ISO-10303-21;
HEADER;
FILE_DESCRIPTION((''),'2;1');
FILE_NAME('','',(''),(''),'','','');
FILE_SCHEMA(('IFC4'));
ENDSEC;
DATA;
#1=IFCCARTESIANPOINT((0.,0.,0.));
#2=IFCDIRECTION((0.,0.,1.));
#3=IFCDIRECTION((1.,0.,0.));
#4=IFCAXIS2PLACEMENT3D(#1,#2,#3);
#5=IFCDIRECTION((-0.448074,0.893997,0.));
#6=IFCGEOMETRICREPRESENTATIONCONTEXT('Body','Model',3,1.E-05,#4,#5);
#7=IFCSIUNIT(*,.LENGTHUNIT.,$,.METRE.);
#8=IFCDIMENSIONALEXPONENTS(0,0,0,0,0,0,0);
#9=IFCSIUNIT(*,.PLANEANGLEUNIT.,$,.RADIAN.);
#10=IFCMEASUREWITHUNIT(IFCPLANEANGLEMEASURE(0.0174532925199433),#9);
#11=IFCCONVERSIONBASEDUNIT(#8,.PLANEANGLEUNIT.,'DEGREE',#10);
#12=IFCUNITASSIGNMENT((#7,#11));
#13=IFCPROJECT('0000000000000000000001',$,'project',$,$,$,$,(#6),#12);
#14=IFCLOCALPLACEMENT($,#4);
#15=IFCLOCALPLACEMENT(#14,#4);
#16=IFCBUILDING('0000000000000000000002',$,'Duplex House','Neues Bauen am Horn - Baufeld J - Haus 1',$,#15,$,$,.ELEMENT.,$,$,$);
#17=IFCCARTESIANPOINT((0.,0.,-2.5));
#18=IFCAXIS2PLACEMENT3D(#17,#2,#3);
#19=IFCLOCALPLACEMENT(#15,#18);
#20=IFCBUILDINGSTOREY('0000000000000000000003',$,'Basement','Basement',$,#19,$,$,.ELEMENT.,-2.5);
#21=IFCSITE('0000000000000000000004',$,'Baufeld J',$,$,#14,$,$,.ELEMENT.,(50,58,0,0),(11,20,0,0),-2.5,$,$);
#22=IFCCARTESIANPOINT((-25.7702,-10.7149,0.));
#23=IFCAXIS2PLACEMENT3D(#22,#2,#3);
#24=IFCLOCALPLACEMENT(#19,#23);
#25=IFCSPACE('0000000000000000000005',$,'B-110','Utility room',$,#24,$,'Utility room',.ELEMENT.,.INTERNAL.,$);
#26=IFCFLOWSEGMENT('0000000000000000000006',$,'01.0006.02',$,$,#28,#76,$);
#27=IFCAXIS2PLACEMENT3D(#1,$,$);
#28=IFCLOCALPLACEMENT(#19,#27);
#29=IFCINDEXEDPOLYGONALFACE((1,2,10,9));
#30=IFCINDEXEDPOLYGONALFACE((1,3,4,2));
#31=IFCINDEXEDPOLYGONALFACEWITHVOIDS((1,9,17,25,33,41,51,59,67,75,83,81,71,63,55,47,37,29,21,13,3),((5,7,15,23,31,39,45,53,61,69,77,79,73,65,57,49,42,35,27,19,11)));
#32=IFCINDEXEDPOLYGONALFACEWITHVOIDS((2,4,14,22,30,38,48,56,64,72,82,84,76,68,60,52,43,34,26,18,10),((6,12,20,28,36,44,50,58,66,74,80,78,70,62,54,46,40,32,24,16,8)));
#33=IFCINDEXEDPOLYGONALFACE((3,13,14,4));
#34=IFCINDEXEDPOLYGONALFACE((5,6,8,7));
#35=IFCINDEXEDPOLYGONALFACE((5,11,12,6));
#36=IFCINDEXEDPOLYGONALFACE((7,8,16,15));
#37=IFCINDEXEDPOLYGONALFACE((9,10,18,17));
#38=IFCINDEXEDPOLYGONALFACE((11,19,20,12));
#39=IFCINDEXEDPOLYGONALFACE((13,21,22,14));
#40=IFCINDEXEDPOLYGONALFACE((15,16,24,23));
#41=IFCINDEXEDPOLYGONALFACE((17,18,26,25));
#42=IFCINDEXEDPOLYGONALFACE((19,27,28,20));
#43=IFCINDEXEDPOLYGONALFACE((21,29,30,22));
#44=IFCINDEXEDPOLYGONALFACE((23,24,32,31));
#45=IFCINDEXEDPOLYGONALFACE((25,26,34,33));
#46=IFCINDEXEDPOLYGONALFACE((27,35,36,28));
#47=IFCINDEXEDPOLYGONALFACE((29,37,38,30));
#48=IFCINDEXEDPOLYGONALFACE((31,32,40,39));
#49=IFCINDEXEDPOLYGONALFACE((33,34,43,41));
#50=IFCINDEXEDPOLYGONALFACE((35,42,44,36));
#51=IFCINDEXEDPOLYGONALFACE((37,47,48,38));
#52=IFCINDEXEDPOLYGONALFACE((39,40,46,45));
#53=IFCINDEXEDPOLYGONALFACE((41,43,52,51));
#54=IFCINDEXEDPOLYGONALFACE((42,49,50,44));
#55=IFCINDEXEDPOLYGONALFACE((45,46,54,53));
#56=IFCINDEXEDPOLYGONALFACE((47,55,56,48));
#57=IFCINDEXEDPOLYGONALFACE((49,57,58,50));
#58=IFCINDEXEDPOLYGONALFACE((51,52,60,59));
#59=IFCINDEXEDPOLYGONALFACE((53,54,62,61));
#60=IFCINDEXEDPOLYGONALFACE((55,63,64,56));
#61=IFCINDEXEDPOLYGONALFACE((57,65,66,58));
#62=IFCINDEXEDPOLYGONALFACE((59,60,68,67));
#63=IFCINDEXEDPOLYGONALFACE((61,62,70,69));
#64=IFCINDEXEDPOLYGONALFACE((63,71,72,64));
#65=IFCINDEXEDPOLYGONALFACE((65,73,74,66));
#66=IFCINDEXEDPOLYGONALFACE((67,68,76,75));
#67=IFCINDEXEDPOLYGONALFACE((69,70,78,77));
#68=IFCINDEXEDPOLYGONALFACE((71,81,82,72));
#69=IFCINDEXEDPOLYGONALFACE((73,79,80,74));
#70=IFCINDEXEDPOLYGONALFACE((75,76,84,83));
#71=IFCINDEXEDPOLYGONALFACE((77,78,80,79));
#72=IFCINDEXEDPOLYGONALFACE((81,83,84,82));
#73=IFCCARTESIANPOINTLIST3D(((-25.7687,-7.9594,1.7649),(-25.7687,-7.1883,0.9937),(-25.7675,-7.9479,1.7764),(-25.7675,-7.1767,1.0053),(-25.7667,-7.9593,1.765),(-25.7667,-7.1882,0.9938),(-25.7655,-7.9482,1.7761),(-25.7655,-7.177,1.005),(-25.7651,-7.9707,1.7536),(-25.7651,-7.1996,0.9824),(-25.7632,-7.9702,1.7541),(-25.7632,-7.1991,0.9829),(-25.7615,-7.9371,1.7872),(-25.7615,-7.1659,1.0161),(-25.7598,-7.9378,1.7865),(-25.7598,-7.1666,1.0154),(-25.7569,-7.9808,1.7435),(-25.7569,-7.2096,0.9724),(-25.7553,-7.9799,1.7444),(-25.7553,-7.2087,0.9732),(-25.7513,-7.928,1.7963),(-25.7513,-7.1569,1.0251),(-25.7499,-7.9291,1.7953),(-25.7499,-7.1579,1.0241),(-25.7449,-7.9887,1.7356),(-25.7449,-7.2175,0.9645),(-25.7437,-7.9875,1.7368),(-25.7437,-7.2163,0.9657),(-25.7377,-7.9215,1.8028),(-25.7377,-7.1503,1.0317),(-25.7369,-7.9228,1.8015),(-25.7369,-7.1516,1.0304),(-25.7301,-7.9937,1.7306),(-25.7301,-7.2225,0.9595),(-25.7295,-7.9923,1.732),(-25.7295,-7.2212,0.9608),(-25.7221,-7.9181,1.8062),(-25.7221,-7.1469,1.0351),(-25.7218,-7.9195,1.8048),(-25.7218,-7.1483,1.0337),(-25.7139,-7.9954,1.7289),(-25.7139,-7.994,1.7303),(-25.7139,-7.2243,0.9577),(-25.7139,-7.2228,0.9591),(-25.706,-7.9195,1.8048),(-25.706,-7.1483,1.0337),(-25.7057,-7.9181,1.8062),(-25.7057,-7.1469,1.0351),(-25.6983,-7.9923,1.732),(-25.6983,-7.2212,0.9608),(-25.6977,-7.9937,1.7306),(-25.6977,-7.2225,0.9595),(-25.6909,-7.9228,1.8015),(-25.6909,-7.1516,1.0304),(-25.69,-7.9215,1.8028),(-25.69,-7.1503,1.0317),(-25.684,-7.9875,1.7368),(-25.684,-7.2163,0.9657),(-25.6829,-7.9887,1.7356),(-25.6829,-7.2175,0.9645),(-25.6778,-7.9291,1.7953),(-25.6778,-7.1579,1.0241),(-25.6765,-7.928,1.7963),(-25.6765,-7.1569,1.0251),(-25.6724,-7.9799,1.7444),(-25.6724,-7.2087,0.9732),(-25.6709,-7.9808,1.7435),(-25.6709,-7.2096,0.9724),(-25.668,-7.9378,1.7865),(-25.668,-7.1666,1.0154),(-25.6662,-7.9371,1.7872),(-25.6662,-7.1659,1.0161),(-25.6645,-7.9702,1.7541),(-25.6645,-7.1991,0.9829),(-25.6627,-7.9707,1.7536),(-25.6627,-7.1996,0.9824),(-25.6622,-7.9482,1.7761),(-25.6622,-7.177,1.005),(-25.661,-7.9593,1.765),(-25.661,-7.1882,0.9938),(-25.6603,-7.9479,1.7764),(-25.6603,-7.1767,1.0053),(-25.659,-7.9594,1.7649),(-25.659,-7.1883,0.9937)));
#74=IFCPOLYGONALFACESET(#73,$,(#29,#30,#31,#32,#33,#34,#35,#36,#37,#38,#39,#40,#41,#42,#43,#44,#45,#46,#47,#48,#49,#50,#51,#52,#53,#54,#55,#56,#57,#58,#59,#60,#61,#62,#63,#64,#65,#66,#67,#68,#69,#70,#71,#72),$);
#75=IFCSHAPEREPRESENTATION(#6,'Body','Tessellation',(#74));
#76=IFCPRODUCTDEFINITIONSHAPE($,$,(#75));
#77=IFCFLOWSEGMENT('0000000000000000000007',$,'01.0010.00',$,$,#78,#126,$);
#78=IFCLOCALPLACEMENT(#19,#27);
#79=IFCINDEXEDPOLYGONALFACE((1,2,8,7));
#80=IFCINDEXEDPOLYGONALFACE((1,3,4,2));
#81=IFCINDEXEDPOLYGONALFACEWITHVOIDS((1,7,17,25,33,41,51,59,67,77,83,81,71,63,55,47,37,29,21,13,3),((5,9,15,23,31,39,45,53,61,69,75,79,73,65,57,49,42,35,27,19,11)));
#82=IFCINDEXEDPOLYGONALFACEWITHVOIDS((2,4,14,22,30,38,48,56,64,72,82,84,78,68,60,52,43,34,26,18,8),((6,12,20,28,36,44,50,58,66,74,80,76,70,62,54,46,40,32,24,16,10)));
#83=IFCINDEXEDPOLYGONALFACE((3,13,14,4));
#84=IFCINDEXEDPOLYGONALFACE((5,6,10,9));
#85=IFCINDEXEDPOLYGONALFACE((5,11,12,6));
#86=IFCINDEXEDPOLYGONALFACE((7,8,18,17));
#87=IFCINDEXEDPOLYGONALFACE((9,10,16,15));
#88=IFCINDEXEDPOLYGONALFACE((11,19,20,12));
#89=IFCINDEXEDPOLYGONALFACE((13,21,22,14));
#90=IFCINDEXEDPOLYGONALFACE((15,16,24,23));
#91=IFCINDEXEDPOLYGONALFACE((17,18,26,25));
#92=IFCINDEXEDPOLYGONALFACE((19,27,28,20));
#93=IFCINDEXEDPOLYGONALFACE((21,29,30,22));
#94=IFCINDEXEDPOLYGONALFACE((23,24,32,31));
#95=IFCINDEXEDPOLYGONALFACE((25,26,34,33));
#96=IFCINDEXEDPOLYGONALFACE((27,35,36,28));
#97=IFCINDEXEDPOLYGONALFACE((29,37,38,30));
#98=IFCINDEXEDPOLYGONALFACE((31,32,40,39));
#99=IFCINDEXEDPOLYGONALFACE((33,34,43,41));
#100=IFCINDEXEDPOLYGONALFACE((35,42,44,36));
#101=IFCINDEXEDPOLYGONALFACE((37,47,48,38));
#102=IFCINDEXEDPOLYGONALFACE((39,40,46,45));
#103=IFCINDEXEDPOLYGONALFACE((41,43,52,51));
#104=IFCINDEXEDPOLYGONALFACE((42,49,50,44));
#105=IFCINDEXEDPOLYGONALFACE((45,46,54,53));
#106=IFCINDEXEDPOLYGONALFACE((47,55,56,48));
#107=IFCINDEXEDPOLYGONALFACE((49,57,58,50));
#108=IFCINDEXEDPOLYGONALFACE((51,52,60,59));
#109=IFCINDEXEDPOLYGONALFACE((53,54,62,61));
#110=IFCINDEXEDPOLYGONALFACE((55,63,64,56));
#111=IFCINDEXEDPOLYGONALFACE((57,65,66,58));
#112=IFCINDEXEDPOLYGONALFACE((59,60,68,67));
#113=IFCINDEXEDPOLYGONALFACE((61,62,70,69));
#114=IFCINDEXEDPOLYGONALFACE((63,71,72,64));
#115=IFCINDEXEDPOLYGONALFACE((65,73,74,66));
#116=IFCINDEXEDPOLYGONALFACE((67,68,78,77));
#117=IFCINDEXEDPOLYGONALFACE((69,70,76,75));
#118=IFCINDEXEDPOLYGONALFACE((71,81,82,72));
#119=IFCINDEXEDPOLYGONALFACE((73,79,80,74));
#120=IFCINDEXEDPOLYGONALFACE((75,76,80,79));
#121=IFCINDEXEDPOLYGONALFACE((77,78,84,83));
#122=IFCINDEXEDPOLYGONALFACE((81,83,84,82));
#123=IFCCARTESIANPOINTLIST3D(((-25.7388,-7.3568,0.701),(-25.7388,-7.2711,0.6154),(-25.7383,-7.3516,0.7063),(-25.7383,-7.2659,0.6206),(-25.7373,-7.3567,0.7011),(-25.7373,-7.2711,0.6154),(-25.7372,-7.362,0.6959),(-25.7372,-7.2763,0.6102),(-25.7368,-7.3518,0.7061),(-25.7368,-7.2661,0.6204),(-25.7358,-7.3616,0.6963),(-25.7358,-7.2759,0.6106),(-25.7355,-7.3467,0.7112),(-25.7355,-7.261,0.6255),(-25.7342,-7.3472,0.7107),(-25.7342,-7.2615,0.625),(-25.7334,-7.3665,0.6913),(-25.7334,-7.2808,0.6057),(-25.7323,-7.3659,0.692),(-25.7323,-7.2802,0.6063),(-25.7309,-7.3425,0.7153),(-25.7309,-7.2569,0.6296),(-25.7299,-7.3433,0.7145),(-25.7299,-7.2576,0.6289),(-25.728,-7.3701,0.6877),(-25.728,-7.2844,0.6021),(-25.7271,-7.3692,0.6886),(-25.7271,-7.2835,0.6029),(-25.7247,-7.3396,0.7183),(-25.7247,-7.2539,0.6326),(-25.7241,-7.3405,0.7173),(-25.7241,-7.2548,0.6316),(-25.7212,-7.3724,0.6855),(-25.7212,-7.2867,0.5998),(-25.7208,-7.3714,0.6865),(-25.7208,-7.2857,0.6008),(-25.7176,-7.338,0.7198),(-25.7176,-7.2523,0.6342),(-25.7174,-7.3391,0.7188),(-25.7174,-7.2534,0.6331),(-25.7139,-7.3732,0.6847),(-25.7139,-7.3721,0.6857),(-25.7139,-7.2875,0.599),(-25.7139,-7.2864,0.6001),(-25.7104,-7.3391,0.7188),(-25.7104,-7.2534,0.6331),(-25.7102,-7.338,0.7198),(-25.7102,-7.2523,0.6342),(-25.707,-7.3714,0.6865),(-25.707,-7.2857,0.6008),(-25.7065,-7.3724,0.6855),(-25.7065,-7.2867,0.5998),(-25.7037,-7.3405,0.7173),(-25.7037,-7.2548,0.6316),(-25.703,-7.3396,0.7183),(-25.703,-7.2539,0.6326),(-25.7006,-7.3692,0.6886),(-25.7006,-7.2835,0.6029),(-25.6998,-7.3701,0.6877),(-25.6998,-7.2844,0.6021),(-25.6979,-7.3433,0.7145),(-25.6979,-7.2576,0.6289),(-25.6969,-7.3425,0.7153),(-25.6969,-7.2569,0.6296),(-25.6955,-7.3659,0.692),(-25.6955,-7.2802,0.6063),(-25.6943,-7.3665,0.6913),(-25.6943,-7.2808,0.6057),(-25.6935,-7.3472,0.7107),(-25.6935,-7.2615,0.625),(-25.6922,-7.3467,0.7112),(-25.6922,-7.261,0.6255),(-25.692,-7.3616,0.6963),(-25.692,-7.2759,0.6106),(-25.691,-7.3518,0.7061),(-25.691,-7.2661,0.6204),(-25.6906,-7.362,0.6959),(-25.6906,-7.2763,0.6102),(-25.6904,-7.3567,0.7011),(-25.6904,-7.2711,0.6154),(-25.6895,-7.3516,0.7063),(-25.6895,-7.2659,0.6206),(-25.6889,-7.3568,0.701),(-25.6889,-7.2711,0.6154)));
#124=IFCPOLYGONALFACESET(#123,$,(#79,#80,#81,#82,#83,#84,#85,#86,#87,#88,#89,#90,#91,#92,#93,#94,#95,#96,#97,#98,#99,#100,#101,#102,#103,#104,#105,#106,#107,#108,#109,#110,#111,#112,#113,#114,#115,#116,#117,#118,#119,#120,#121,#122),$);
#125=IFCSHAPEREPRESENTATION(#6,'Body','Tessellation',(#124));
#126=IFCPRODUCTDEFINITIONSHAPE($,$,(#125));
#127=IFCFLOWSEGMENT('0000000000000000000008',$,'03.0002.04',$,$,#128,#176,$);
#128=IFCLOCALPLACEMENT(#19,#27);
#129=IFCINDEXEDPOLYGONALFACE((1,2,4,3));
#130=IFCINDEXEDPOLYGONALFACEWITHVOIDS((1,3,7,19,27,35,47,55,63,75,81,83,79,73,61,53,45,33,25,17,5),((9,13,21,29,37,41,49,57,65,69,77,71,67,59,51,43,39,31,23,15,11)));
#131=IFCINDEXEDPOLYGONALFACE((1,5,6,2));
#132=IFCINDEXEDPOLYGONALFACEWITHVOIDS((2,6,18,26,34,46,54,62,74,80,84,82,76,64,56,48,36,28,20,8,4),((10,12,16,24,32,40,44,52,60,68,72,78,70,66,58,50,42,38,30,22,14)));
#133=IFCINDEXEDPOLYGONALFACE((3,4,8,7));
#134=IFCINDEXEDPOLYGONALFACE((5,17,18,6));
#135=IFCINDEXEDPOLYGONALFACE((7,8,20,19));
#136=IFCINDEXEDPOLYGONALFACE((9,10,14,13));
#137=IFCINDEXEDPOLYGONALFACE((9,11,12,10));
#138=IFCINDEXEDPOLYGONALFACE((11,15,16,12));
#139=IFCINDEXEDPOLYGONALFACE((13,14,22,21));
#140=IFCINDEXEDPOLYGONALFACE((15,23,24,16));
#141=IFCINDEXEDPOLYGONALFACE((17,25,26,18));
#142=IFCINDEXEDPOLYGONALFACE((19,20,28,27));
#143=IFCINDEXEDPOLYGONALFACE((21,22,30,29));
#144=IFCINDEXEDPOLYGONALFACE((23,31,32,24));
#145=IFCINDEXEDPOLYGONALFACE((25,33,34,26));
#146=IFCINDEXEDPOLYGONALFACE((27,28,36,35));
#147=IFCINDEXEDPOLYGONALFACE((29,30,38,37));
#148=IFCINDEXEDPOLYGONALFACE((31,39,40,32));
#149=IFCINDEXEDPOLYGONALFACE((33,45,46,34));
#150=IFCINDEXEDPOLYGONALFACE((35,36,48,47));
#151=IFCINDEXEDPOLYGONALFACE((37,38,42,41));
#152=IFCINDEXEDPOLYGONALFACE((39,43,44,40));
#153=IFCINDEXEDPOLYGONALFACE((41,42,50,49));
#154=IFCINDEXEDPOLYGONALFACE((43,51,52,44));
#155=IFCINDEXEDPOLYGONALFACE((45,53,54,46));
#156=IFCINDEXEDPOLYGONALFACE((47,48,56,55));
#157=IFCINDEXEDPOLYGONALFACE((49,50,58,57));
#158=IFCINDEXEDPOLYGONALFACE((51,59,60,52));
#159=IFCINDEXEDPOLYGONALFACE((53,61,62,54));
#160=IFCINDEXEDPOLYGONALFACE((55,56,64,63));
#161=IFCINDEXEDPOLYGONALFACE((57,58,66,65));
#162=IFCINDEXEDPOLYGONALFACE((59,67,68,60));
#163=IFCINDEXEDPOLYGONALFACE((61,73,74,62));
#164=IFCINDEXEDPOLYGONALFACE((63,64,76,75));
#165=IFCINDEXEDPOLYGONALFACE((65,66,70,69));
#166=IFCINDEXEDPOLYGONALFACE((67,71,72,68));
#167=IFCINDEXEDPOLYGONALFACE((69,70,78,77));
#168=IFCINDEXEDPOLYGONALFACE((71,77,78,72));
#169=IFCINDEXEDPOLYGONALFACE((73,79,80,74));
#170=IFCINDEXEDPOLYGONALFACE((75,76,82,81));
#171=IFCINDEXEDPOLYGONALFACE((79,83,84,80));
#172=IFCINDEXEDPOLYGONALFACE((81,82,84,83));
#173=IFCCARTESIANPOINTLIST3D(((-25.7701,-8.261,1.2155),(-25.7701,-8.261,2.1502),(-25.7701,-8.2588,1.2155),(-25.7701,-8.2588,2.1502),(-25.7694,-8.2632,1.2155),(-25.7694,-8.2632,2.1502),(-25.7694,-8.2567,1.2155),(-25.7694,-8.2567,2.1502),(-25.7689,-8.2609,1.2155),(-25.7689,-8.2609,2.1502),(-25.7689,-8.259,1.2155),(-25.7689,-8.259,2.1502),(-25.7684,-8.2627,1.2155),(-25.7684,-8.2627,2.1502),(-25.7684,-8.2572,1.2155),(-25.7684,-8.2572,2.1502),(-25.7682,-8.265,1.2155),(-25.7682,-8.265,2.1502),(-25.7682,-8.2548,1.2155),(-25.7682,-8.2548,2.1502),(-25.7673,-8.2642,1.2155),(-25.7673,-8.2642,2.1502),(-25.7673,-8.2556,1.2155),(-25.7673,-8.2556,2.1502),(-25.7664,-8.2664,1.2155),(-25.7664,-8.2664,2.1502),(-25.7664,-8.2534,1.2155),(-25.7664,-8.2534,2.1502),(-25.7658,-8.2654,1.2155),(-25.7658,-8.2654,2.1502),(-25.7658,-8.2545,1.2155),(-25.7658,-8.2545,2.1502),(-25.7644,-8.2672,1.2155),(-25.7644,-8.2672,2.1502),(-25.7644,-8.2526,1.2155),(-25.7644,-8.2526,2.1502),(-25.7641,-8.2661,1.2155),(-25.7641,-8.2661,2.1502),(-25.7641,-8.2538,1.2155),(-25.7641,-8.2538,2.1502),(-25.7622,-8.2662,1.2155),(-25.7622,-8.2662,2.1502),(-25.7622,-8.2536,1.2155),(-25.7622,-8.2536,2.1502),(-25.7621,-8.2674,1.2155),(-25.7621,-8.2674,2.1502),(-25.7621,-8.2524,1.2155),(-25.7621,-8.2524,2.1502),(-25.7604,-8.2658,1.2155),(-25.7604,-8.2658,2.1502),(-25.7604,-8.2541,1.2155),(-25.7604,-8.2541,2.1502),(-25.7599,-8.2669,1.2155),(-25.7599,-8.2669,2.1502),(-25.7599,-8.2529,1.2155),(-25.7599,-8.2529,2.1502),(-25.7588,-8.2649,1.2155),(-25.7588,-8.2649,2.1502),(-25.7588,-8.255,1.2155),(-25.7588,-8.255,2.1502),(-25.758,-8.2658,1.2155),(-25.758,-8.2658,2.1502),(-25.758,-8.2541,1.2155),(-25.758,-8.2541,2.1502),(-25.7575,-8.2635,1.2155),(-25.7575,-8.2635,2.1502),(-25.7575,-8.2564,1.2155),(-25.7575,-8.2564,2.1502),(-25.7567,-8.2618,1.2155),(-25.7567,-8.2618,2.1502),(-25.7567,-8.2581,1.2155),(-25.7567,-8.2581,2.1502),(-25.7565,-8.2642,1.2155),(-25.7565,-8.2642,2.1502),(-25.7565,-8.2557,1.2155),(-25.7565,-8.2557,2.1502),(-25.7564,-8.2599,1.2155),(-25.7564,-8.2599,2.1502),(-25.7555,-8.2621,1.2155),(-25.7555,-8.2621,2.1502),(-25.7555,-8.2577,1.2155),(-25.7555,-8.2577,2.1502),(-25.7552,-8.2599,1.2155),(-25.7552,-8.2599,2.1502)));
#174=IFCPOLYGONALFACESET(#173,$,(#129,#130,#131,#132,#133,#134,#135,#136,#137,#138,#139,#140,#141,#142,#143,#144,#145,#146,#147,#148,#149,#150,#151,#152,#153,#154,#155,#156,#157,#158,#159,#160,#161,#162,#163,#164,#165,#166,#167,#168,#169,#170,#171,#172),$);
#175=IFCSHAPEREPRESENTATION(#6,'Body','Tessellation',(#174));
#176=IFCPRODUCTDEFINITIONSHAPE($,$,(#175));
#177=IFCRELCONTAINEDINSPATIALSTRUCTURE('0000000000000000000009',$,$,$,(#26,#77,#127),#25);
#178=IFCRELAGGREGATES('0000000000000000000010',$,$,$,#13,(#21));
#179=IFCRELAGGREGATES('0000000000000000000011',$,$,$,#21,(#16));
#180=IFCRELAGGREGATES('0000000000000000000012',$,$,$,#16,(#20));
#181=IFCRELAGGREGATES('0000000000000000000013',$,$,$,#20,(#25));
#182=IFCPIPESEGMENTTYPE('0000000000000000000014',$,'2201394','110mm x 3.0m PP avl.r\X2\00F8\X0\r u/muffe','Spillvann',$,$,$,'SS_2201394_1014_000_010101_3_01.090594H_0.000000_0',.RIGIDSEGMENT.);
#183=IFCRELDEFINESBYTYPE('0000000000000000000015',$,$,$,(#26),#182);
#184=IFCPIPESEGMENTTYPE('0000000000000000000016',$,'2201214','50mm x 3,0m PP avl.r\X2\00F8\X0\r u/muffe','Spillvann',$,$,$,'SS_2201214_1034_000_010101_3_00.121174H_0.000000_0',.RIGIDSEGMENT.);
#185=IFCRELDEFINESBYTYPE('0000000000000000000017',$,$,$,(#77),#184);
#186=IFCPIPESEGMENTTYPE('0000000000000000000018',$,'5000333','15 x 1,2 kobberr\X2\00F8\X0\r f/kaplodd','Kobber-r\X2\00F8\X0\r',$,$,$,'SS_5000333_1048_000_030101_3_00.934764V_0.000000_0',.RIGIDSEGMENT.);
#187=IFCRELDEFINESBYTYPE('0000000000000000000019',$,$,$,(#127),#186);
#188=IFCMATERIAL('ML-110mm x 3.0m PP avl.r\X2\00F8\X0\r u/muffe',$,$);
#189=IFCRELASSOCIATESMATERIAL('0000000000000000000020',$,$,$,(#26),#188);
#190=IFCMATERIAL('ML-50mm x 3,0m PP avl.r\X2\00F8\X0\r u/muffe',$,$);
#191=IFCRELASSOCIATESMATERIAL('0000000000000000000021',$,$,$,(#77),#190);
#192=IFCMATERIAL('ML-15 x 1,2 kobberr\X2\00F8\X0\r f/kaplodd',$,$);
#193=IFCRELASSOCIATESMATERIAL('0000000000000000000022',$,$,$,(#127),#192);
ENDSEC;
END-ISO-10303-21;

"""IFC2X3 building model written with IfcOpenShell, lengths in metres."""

from ifc_helpers import new_model, entity, si_unit, converted_unit, direction, frame, origin_with_axes, origin_2d_with_axis, place, context, project, spatial, hollow_circle, extrude, material, type_object, element, save


model = new_model("IFC2X3")

# Units and contexts
model_context = context("Model", 3, precision=1e-05, world=origin_with_axes(), true_north=direction((-0.448074, 0.893997, 0.0)), identifier="Body")
ifc_project = project(units=[si_unit("LENGTHUNIT", "METRE"), converted_unit("PLANEANGLEUNIT", "DEGREE", entity("IfcPlaneAngleMeasure", 0.0174532925199433), si_unit("PLANEANGLEUNIT", "RADIAN"), dimensions=[0, 0, 0, 0, 0, 0, 0])], contexts=[model_context])

# Site, building, storey, space
site_placement = place(None, origin_with_axes())
site = spatial("IfcSite", under=ifc_project, at=site_placement, Name="Baufeld J", CompositionType="ELEMENT", RefLatitude=(50, 58, 0, 0), RefLongitude=(11, 20, 0, 0), RefElevation=-2.5)
building_placement = place(site_placement, origin_with_axes())
building = spatial("IfcBuilding", under=site, at=building_placement, Name="Duplex House", Description="Neues Bauen am Horn - Baufeld J - Haus 1", CompositionType="ELEMENT")
storey_placement = place(building_placement, frame((0.0, 0.0, -2.5), z_axis=(0.0, 0.0, 1.0), x_axis=(1.0, 0.0, 0.0)))
storey = spatial("IfcBuildingStorey", under=building, at=storey_placement, Name="Basement", Description="Basement", CompositionType="ELEMENT", Elevation=-2.5)
space_1_placement = place(storey_placement, frame((-25.7702, -10.7149, 0.0), z_axis=(0.0, 0.0, 1.0), x_axis=(1.0, 0.0, 0.0)))
space_1 = spatial("IfcSpace", under=storey, at=space_1_placement, Name="B-110", Description="Utility room", LongName="Utility room", CompositionType="ELEMENT", InteriorOrExteriorSpace="INTERNAL")

# Flow segments
ifc_material_1 = material(Name="ML-110mm x 3.0m PP avl.rør u/muffe")
pipe_segment_type_1 = type_object("IfcPipeSegmentType", Name="2201394", Description="110mm x 3.0m PP avl.rør u/muffe", ApplicableOccurrence="Spillvann", ElementType="SS_2201394_1014_000_010101_3_01.090594H_0.000000_0", PredefinedType="RIGIDSEGMENT")
flow_segment_1_placement = place(space_1_placement, frame((0.0563, 2.7584, 1.7678), z_axis=(0.0, 0.707107, 0.707107), x_axis=(0.0, 0.707107, -0.707107)))
element("IfcFlowSegment", 1, at=flow_segment_1_placement, inside=space_1, type_object=pipe_segment_type_1, material=ifc_material_1, Name="01.0006.02", context=model_context, shape_type="SweptSolid", body=[
    extrude(hollow_circle(Radius=0.055, WallThickness=0.002, at=origin_2d_with_axis()), frame((0.0, 0.0, 0.0), z_axis=(1.0, 0.0, 0.0), x_axis=(0.0, 0.0, -1.0)), (0.0, 0.0, 1.0), 1.0906),
])
ifc_material_2 = material(Name="ML-50mm x 3,0m PP avl.rør u/muffe")
pipe_segment_type_2 = type_object("IfcPipeSegmentType", Name="2201214", Description="50mm x 3,0m PP avl.rør u/muffe", ApplicableOccurrence="Spillvann", ElementType="SS_2201214_1034_000_010101_3_00.121174H_0.000000_0", PredefinedType="RIGIDSEGMENT")
flow_segment_2_placement = place(space_1_placement, frame((0.0563, 3.4451, 0.6167), z_axis=(0.0, 0.707107, 0.707107), x_axis=(0.0, -0.707107, 0.707107)))
element("IfcFlowSegment", 2, at=flow_segment_2_placement, inside=space_1, type_object=pipe_segment_type_2, material=ifc_material_2, Name="01.0010.00", context=model_context, shape_type="SweptSolid", body=[
    extrude(hollow_circle(Radius=0.025, WallThickness=0.0015, at=origin_2d_with_axis()), frame((0.0, 0.0, 0.0), z_axis=(1.0, 0.0, 0.0), x_axis=(0.0, 0.0, -1.0)), (0.0, 0.0, 1.0), 0.1212),
])
ifc_material_3 = material(Name="ML-15 x 1,2 kobberrør f/kaplodd")

# Flow segment
pipe_segment_type_3 = type_object("IfcPipeSegmentType", Name="5000333", Description="15 x 1,2 kobberrør f/kaplodd", ApplicableOccurrence="Kobber-rør", ElementType="SS_5000333_1048_000_030101_3_00.934764V_0.000000_0", PredefinedType="RIGIDSEGMENT")
flow_segment_3_placement = place(space_1_placement, frame((0.0075, 2.455, 2.1502), z_axis=(-1.0, 0.0, 0.0), x_axis=(0.0, 0.0, -1.0)))
element("IfcFlowSegment", 3, at=flow_segment_3_placement, inside=space_1, type_object=pipe_segment_type_3, material=ifc_material_3, Name="03.0002.04", context=model_context, shape_type="SweptSolid", body=[
    extrude(hollow_circle(Radius=0.0075, WallThickness=0.0012, at=origin_2d_with_axis()), frame((0.0, 0.0, 0.0), z_axis=(1.0, 0.0, 0.0), x_axis=(0.0, 0.0, -1.0)), (0.0, 0.0, 1.0), 0.9348),
])

save(model, "model.ifc")
